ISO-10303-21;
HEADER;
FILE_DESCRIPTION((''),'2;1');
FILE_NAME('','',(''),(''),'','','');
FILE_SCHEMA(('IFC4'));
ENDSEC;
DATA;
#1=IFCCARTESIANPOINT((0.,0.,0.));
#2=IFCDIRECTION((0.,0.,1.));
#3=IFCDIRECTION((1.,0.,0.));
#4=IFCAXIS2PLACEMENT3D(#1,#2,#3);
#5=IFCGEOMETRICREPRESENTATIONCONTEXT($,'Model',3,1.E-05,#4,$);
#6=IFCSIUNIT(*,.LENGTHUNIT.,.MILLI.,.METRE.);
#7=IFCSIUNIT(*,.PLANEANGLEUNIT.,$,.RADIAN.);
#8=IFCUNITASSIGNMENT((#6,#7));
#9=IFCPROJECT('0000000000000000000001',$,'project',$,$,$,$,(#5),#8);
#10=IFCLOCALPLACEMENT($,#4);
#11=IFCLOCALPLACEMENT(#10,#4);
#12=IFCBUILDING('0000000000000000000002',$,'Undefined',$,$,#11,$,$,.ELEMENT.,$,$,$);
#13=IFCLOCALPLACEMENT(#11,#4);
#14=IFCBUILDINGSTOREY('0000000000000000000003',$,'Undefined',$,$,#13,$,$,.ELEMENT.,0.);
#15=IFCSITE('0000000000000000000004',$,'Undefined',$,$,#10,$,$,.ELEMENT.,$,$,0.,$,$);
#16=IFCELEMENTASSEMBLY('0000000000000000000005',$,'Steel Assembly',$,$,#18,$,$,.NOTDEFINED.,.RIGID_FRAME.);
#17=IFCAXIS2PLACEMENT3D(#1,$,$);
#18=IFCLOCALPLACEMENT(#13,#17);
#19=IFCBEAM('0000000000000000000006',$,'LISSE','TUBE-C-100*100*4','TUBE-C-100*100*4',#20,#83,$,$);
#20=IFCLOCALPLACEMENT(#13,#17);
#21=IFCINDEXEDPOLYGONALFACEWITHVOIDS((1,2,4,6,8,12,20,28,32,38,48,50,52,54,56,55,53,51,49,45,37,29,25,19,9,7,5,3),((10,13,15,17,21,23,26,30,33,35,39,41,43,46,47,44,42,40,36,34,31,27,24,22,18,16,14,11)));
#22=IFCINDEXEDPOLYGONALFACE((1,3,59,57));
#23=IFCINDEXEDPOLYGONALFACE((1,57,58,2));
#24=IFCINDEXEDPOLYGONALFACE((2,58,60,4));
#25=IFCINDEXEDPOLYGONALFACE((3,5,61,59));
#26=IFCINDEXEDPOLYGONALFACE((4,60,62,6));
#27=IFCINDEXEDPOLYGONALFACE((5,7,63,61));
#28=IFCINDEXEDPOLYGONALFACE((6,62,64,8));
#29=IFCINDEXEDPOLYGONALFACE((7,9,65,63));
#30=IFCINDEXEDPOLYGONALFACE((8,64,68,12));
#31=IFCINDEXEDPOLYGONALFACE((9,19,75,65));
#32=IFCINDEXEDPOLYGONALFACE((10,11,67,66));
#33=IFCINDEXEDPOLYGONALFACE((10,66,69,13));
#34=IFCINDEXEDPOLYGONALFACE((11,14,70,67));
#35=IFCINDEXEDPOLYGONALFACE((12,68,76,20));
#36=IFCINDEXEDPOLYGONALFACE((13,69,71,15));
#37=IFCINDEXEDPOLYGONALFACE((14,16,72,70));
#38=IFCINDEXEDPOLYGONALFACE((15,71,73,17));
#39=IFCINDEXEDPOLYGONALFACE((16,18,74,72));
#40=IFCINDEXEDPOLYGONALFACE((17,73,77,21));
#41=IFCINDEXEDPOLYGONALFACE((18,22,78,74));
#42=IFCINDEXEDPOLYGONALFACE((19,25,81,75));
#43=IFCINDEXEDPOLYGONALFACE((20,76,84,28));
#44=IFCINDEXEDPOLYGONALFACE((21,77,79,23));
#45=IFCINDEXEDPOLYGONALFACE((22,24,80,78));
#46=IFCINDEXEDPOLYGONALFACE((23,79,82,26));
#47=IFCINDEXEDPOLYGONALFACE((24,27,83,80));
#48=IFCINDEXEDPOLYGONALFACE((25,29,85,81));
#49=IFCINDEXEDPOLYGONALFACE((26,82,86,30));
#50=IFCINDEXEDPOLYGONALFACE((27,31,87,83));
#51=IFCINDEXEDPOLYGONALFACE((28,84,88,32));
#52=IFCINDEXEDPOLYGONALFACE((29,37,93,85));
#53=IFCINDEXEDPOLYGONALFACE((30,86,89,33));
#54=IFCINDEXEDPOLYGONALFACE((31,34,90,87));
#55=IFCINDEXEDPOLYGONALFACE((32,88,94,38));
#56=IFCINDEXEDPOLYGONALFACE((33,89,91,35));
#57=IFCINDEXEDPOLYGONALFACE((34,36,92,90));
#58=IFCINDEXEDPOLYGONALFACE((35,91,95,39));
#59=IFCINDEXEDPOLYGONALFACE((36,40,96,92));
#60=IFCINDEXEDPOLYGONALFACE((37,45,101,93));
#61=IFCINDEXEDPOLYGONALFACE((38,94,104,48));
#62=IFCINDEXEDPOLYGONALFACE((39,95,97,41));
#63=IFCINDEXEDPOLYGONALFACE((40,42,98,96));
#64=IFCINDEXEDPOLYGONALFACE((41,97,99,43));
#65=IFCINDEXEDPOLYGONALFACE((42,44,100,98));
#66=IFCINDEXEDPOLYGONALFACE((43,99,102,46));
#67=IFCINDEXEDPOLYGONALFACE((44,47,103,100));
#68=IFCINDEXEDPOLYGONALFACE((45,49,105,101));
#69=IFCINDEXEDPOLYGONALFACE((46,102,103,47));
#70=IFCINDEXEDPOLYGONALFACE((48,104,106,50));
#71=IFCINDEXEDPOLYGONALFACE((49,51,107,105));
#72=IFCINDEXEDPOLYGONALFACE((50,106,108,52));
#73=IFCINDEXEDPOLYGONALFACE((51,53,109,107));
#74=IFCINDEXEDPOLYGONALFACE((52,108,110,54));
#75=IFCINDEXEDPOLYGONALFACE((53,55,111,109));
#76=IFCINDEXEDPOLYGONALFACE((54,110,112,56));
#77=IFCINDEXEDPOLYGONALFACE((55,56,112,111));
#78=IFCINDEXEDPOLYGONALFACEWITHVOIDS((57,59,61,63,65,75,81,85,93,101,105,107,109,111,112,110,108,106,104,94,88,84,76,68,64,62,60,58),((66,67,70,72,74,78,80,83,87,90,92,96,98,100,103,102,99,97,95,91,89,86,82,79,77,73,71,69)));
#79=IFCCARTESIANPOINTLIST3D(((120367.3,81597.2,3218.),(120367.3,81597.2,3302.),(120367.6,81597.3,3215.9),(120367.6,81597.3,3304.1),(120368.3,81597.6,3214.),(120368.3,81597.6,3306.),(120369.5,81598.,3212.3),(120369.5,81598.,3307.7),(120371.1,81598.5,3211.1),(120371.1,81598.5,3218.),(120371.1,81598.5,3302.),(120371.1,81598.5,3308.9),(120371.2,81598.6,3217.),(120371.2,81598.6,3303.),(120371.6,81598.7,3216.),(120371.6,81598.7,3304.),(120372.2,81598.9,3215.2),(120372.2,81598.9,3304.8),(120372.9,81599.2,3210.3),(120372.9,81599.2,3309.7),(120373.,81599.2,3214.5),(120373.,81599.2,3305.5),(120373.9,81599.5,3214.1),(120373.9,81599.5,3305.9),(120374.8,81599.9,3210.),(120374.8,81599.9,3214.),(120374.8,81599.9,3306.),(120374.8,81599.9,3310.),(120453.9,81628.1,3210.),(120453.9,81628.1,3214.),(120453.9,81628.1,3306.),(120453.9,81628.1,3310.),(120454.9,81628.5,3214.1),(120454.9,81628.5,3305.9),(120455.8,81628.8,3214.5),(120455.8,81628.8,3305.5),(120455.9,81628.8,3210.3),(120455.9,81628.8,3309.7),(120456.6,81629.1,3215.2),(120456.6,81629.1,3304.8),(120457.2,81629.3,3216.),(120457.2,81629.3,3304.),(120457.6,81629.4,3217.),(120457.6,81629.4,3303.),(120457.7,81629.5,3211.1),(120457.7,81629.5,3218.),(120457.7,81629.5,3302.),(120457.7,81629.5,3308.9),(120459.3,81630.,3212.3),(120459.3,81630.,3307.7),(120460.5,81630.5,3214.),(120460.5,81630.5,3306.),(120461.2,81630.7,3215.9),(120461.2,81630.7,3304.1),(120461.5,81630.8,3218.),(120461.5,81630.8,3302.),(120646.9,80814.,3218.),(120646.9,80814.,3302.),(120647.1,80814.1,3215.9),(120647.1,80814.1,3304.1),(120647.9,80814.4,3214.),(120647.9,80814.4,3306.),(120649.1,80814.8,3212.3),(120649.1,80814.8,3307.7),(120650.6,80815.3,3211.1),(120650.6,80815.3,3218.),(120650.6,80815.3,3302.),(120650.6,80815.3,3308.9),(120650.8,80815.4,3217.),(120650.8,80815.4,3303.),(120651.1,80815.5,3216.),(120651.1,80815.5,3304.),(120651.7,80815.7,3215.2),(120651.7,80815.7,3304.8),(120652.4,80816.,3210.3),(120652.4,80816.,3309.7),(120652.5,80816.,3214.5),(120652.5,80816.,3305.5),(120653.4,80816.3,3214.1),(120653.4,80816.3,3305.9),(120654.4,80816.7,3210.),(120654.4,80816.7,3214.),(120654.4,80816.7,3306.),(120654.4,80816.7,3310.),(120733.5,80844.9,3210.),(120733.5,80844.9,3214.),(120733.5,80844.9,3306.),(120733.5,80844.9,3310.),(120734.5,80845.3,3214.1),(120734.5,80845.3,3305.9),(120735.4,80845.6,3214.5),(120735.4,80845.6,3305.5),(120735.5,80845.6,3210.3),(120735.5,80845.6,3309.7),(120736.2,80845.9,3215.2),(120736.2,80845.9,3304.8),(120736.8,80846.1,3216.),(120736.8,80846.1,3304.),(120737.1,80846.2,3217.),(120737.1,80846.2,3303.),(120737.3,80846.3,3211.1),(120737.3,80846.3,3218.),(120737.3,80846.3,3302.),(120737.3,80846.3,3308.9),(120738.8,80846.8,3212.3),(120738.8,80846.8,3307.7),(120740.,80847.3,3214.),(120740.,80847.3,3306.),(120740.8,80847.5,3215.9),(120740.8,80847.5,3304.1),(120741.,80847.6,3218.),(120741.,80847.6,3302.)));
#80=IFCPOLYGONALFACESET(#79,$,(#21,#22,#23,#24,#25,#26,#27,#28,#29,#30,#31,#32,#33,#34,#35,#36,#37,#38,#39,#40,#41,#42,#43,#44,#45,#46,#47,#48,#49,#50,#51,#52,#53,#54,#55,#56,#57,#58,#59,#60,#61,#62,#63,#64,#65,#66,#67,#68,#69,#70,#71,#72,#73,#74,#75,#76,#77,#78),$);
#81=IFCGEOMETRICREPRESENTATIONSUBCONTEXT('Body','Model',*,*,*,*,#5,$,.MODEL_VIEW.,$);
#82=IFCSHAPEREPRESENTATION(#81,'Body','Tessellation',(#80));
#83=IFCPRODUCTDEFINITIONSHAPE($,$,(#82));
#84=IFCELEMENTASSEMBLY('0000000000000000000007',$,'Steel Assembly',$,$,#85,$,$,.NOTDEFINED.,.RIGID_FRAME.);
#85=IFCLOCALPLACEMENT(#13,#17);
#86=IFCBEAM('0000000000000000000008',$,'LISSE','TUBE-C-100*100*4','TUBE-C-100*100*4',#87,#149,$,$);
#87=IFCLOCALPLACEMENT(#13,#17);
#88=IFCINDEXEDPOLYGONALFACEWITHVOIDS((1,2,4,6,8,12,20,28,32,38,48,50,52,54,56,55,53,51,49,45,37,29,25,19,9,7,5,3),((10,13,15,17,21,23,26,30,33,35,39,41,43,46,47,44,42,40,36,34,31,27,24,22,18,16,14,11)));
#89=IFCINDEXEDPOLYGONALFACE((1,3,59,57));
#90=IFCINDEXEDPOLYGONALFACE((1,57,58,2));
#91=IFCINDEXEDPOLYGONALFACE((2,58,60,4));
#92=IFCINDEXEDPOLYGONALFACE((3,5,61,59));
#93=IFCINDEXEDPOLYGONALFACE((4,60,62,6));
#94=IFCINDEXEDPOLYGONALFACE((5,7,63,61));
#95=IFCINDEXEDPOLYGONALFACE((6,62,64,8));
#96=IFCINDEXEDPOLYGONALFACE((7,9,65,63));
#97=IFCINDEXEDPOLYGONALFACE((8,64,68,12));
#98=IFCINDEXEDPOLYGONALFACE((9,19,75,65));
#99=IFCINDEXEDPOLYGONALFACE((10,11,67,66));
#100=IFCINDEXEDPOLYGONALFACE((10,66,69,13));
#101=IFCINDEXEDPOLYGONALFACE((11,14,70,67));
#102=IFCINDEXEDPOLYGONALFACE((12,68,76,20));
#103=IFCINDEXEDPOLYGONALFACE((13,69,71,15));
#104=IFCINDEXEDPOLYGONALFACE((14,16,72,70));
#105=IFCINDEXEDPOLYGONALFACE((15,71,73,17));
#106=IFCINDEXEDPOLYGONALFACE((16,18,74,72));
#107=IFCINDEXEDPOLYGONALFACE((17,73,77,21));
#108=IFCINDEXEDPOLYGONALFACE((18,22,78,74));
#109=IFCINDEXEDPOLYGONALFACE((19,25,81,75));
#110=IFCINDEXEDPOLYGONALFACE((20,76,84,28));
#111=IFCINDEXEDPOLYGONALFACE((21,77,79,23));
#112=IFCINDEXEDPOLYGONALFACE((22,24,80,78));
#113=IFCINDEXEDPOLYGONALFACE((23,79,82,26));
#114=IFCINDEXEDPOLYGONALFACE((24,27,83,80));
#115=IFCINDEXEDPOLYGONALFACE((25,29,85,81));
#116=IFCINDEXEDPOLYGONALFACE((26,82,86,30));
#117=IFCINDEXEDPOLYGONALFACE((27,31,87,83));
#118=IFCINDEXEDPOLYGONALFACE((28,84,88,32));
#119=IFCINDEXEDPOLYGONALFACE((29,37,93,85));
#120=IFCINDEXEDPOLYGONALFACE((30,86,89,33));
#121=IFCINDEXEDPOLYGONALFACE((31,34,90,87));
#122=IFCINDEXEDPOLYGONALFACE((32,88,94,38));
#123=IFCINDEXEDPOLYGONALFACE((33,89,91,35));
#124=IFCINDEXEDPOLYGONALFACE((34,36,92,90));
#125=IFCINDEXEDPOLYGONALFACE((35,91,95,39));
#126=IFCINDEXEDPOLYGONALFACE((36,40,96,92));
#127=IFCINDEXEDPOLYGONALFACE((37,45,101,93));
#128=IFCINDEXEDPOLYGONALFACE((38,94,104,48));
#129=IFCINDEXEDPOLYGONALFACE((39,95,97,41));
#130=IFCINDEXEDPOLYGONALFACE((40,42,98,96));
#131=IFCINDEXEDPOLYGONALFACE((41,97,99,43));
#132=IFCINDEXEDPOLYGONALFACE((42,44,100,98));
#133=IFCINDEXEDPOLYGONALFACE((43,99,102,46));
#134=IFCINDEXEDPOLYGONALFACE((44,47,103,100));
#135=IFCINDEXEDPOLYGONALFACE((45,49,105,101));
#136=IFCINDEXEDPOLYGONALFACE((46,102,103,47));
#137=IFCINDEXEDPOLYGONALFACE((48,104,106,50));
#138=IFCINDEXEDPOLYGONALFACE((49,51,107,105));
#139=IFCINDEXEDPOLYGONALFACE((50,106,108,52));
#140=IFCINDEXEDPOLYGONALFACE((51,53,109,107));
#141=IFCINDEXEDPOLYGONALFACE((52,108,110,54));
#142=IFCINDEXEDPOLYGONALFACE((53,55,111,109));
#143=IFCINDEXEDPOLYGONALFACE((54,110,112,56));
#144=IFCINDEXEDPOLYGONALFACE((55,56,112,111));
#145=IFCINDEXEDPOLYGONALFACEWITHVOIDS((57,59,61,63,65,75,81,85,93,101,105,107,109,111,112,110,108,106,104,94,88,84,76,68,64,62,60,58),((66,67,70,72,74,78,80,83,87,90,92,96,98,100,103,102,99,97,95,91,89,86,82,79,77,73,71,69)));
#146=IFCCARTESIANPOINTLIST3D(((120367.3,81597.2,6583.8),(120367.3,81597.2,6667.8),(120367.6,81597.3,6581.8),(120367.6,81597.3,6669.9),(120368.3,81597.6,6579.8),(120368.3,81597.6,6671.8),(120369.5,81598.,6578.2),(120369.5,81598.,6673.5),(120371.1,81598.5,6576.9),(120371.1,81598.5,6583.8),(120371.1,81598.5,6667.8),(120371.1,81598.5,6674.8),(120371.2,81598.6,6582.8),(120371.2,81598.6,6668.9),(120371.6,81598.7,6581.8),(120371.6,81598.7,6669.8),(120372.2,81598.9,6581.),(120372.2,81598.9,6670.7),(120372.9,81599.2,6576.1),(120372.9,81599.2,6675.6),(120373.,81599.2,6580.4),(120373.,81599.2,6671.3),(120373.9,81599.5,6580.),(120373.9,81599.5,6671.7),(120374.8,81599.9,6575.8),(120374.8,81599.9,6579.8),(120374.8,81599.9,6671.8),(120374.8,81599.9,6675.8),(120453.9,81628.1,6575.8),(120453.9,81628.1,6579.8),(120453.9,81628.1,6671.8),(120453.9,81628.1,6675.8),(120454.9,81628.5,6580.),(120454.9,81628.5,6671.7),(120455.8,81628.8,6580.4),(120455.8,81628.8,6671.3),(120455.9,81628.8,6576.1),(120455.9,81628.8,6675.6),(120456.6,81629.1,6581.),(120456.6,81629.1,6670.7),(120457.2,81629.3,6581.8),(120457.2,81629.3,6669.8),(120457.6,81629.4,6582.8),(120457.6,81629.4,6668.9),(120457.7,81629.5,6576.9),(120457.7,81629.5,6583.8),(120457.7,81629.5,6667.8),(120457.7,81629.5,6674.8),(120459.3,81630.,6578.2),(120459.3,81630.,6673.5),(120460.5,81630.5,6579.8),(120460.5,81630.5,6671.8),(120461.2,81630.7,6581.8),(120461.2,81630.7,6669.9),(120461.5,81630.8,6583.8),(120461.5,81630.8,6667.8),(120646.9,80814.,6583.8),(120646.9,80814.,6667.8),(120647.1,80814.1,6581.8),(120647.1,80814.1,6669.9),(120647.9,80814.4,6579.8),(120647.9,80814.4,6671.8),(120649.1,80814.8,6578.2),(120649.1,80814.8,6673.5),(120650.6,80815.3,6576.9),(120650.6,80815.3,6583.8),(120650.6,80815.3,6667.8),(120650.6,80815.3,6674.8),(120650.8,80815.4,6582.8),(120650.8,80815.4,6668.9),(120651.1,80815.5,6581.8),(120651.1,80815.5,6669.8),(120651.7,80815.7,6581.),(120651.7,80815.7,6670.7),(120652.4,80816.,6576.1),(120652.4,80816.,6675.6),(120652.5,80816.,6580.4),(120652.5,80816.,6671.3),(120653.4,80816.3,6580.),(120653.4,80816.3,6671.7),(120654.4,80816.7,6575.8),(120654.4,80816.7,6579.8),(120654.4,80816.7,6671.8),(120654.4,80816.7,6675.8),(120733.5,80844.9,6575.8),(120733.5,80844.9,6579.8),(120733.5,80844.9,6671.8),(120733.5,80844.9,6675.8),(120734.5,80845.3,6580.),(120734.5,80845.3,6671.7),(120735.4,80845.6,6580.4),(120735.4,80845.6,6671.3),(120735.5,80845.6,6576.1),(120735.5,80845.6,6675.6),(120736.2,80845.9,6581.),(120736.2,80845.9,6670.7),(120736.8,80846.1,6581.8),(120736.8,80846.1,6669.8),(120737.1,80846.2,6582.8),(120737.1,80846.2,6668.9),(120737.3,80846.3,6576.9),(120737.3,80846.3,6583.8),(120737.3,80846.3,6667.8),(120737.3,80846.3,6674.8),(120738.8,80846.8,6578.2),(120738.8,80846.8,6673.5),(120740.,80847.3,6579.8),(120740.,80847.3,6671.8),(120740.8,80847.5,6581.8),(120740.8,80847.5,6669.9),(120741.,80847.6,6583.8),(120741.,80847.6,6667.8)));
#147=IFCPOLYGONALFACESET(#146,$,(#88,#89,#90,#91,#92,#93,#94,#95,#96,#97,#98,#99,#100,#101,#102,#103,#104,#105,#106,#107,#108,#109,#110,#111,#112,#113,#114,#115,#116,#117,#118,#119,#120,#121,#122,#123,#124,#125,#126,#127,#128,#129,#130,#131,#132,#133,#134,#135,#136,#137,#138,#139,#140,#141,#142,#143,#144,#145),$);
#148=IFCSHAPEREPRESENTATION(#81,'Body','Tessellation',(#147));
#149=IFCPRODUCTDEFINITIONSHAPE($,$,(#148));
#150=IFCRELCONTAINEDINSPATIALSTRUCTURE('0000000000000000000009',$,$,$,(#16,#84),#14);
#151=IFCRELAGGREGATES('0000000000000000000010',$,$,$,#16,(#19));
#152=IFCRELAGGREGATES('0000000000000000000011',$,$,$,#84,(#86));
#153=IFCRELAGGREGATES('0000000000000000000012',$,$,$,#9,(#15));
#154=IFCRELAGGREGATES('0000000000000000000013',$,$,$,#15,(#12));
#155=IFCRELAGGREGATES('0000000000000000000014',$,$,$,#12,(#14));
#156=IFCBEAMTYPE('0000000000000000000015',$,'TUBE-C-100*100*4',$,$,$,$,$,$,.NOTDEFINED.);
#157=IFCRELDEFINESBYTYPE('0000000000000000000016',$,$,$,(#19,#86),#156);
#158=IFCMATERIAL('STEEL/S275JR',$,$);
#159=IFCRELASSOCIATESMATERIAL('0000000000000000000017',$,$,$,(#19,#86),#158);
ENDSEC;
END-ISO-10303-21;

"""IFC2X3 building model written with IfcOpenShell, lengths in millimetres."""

from ifc_helpers import new_model, si_unit, frame, origin_with_axes, origin_2d_with_axis, place, context, subcontext, project, spatial, hollow_rectangle, extrude, material, type_object, element, aggregate, save


model = new_model("IFC2X3")

# Units and contexts
model_context = context("Model", 3, precision=1e-05, world=origin_with_axes())
body_context = subcontext(model_context, "Body", "Model", "MODEL_VIEW")
ifc_project = project(units=[si_unit("LENGTHUNIT", "METRE", prefix="MILLI"), si_unit("PLANEANGLEUNIT", "RADIAN")], contexts=[model_context])

# Site, building, storey
site_placement = place(None, origin_with_axes())
site = spatial("IfcSite", under=ifc_project, at=site_placement, Name="Undefined", CompositionType="ELEMENT", RefElevation=0.0)
building_placement = place(site_placement, origin_with_axes())
building = spatial("IfcBuilding", under=site, at=building_placement, Name="Undefined", CompositionType="ELEMENT")
storey_placement = place(building_placement, origin_with_axes())
storey = spatial("IfcBuildingStorey", under=building, at=storey_placement, Name="Undefined", CompositionType="ELEMENT", Elevation=0.0)

# Shared definitions
ifc_material = material(Name="STEEL/S275JR")

# Element assemblies, beams
beam_type_1 = type_object("IfcBeamType", Name="TUBE-C-100*100*4", PredefinedType="NOTDEFINED")
assembly_1_placement = place(storey_placement, origin_with_axes())
assembly_1 = element("IfcElementAssembly", 1, at=assembly_1_placement, inside=storey, Name="Steel Assembly", AssemblyPlace="NOTDEFINED", PredefinedType="RIGID_FRAME")
beam_1_placement = place(assembly_1_placement, frame((120693.9, 80830.8, 3260.0), z_axis=(0.941802, 0.336168, 0.0), x_axis=(-0.336168, 0.941802, 0.0)))
beam_1 = element("IfcBeam", 2, at=beam_1_placement, type_object=beam_type_1, material=ifc_material, Name="LISSE", Description="TUBE-C-100*100*4", ObjectType="TUBE-C-100*100*4", context=body_context, shape_type="SweptSolid", body=[
    extrude(hollow_rectangle(XDim=100.0, YDim=100.0, WallThickness=4.0, InnerFilletRadius=4.0, OuterFilletRadius=8.0, at=origin_2d_with_axis()), frame((831.6, 0.0, 0.0), z_axis=(-1.0, 0.0, 0.0), x_axis=(0.0, -1.0, 0.0)), (0.0, 0.0, 1.0), 831.6),
])
aggregate(assembly_1, [beam_1])
assembly_2_placement = place(storey_placement, origin_with_axes())
assembly_2 = element("IfcElementAssembly", 3, at=assembly_2_placement, inside=storey, Name="Steel Assembly", AssemblyPlace="NOTDEFINED", PredefinedType="RIGID_FRAME")
beam_2_placement = place(assembly_2_placement, frame((120693.9, 80830.8, 6625.8), z_axis=(0.941802, 0.336168, 0.0), x_axis=(-0.336168, 0.941802, 0.0)))
beam_2 = element("IfcBeam", 4, at=beam_2_placement, type_object=beam_type_1, material=ifc_material, Name="LISSE", Description="TUBE-C-100*100*4", ObjectType="TUBE-C-100*100*4", context=body_context, shape_type="SweptSolid", body=[
    extrude(hollow_rectangle(XDim=100.0, YDim=100.0, WallThickness=4.0, InnerFilletRadius=4.0, OuterFilletRadius=8.0, at=origin_2d_with_axis()), frame((831.6, 0.0, 0.0), z_axis=(-1.0, 0.0, 0.0), x_axis=(0.0, -1.0, 0.0)), (0.0, 0.0, 1.0), 831.6),
])
aggregate(assembly_2, [beam_2])

save(model, "model.ifc")
